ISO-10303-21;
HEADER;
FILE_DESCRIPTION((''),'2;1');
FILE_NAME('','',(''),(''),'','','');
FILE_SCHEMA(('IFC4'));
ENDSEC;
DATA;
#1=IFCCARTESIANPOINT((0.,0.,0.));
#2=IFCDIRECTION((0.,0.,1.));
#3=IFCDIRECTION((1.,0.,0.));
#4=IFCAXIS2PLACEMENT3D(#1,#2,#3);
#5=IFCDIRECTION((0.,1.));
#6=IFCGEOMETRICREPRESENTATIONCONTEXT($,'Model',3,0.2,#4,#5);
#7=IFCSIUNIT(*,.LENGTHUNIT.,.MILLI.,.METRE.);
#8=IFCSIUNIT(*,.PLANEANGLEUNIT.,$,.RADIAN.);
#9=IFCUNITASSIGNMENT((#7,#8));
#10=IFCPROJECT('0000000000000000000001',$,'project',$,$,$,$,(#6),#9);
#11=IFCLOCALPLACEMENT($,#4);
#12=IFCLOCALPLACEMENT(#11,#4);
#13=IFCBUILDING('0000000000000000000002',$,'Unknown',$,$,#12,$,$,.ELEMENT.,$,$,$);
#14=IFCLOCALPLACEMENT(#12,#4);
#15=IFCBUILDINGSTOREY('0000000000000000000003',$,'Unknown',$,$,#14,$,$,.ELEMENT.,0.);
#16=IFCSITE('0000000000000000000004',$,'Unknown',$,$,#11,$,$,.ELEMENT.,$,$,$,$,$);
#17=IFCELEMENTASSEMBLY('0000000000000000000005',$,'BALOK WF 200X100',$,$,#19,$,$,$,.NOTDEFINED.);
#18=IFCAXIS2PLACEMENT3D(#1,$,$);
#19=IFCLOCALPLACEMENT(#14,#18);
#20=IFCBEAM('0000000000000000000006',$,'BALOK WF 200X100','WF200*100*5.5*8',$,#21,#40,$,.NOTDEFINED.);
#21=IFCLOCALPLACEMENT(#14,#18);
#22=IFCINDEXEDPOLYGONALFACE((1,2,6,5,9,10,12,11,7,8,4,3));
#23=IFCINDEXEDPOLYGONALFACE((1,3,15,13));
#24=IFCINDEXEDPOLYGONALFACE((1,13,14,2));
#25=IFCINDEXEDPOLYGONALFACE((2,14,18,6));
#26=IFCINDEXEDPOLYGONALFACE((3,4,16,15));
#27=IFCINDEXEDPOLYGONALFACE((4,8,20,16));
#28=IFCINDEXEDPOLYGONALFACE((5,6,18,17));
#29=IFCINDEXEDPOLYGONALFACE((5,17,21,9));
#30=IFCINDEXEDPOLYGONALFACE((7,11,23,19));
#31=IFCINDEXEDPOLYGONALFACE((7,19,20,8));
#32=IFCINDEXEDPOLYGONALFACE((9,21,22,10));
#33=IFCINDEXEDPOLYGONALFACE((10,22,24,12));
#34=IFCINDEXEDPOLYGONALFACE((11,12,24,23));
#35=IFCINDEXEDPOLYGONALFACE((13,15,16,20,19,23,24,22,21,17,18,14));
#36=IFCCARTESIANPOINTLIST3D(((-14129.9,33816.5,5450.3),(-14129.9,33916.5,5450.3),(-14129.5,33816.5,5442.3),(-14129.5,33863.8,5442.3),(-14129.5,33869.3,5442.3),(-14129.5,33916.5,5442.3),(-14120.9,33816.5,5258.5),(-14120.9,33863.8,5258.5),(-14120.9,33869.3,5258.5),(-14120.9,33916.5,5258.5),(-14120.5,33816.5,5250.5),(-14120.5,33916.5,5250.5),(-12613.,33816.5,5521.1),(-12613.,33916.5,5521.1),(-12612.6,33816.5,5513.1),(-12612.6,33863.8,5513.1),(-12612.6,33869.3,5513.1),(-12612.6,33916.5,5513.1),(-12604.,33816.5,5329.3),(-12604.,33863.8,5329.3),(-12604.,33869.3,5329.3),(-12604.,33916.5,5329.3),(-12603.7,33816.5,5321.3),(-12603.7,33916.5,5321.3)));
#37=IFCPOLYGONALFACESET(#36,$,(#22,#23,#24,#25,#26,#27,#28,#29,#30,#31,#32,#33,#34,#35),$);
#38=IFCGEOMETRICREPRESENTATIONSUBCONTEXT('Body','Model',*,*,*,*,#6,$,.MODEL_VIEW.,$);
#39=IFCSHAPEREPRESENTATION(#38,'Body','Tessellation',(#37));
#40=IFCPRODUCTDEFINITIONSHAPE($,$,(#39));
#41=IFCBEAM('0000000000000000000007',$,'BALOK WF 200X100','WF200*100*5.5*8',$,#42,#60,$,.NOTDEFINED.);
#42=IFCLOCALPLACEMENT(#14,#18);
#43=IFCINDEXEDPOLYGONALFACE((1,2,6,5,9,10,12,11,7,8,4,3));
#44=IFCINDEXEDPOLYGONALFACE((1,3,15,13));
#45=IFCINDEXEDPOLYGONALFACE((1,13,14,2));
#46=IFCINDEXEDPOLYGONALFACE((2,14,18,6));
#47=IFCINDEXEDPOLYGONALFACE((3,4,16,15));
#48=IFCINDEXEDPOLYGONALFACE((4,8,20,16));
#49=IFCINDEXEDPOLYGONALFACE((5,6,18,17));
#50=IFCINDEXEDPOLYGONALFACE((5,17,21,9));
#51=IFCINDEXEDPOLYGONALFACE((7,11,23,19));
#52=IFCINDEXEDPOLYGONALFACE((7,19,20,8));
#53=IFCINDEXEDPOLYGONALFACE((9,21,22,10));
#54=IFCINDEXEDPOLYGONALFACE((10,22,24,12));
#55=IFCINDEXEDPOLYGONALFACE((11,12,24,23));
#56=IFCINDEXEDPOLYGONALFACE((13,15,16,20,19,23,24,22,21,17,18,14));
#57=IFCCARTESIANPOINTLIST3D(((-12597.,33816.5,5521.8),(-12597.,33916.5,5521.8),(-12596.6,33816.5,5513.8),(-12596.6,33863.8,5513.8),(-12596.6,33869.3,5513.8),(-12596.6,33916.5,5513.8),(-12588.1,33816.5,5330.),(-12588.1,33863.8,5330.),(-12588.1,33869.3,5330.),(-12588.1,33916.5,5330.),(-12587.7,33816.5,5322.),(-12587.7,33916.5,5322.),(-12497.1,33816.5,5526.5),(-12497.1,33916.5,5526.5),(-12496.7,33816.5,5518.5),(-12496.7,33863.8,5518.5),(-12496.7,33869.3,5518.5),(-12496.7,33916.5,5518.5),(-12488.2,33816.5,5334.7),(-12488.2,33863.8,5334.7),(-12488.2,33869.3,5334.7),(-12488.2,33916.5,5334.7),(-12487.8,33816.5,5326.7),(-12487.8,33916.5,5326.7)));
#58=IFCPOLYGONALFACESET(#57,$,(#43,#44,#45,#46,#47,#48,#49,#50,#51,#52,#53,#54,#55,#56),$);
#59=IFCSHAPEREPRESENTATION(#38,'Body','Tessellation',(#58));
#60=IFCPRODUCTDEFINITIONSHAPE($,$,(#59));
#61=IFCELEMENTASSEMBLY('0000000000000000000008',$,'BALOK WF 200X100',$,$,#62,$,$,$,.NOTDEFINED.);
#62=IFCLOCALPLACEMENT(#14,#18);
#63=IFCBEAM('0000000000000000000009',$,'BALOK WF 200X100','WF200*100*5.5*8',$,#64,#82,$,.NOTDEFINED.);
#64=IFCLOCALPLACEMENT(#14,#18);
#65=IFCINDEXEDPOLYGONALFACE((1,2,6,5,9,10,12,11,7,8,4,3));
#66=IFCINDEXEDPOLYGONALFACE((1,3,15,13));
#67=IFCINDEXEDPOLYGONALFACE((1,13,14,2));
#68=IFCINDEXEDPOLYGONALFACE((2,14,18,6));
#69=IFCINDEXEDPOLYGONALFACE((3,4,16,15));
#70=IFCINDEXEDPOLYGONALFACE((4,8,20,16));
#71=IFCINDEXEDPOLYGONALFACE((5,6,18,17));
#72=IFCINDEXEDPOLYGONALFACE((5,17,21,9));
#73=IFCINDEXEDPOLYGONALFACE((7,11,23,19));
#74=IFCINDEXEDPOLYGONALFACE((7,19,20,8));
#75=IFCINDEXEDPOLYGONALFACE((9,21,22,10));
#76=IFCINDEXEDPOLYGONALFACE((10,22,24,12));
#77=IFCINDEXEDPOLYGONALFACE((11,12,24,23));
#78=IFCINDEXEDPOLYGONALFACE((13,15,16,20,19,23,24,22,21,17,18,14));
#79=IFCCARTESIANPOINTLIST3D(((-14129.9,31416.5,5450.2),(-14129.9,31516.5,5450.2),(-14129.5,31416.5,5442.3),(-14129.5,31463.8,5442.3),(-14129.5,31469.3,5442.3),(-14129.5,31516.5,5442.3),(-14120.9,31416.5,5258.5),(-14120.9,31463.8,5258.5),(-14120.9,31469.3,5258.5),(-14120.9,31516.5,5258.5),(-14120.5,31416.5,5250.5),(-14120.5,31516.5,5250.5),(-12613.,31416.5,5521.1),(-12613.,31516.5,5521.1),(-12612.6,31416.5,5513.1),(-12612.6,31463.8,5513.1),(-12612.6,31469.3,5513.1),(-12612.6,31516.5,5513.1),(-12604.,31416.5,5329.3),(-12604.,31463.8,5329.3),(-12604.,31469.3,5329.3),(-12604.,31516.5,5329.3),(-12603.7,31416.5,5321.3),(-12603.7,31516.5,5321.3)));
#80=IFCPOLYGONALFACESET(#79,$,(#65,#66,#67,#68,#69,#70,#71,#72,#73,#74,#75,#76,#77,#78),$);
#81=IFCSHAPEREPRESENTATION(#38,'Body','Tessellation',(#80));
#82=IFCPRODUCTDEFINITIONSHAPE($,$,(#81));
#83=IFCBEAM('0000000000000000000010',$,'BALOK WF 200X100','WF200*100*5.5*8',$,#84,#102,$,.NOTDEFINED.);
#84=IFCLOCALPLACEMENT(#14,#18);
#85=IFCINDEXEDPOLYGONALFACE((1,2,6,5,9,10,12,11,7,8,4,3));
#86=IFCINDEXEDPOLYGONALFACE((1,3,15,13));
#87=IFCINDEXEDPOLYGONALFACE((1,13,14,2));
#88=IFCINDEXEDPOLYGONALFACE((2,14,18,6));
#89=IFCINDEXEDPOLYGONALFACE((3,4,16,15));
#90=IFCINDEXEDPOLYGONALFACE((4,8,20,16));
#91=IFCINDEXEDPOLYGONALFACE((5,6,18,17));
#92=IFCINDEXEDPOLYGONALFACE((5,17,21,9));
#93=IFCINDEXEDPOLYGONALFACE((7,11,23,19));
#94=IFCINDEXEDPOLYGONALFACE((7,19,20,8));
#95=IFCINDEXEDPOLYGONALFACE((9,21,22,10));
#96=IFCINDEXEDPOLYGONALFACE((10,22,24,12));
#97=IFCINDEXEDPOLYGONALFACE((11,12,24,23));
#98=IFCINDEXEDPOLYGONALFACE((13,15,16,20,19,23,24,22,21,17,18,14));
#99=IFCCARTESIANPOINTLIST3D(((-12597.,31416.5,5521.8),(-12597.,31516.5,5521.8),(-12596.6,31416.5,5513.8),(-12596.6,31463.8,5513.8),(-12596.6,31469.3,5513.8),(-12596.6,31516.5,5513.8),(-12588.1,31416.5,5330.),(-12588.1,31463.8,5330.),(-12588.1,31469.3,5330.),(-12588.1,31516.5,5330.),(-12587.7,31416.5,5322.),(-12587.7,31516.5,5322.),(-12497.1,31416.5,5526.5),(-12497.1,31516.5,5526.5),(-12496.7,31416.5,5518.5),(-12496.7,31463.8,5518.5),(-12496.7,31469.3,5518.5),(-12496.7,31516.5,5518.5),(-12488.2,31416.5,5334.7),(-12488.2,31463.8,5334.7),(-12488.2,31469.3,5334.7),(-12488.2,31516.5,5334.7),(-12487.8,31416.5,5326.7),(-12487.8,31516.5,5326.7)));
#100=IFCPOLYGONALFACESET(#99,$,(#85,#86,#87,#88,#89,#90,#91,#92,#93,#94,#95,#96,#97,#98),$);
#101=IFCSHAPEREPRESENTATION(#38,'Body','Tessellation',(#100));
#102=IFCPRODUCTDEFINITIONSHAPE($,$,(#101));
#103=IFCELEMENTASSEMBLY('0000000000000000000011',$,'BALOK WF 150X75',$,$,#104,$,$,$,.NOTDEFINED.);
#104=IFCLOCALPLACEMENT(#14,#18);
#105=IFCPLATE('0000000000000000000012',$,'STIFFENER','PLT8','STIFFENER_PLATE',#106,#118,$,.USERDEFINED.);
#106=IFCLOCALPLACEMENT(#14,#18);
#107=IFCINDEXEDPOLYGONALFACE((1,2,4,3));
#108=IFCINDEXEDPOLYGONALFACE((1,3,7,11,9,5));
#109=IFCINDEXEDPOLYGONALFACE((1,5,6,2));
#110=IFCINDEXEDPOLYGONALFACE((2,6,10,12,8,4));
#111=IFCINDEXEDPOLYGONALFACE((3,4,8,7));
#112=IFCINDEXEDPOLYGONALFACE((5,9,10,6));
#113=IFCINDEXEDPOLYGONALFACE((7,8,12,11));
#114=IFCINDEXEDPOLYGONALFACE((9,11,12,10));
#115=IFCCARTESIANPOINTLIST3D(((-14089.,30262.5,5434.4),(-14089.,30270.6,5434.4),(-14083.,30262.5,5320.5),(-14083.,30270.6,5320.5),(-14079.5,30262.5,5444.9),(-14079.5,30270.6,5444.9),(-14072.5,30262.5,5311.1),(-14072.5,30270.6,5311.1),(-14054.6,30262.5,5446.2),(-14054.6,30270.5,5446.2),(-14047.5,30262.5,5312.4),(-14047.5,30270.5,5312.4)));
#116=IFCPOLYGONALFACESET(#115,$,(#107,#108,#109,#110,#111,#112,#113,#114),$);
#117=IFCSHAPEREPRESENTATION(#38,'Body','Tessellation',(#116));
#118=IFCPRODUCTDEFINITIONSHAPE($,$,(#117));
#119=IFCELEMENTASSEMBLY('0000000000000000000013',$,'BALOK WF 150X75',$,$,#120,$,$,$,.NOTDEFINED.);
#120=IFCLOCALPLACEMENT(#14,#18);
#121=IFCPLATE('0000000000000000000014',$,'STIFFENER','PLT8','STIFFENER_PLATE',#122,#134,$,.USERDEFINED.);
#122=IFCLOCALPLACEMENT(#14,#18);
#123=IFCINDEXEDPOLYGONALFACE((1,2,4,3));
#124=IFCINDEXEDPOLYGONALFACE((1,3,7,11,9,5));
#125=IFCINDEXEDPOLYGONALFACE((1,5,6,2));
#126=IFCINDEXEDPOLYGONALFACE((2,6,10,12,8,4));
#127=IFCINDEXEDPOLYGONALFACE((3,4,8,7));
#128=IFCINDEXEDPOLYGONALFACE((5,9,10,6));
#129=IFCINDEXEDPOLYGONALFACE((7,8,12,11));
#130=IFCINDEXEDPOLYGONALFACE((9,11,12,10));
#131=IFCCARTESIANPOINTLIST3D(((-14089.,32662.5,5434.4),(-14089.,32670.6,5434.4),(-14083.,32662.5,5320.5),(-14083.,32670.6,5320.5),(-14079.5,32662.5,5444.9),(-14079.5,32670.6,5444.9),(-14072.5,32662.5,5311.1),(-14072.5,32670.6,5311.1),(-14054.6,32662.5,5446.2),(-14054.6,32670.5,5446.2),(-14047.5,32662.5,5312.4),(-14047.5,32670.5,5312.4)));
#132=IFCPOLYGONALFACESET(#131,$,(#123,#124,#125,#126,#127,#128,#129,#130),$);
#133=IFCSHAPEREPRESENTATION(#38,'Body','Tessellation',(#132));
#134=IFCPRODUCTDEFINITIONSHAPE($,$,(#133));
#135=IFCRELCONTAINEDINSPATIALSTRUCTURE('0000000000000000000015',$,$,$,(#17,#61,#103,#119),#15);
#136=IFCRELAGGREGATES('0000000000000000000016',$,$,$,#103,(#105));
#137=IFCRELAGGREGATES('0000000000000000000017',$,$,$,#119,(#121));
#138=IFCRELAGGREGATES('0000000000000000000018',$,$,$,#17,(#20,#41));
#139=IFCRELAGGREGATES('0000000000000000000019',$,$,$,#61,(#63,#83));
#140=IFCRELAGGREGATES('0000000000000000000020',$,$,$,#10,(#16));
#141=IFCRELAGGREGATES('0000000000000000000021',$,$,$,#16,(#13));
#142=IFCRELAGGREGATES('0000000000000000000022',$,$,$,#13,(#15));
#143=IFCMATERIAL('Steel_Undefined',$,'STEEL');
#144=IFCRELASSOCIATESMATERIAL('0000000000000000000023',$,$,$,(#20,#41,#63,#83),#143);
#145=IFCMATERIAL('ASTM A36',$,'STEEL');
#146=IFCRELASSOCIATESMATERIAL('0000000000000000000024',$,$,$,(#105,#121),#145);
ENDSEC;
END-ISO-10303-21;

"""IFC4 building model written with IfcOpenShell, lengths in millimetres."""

from ifc_helpers import new_model, si_unit, direction, frame, origin_with_axes, place, context, subcontext, project, spatial, line, indexed_curve, outline, extrude, material, element, aggregate, save


model = new_model("IFC4")

# Units and contexts
model_context = context("Model", 3, precision=0.2, world=origin_with_axes(), true_north=direction((0.0, 1.0)))
body_context = subcontext(model_context, "Body", "Model", "MODEL_VIEW")
ifc_project = project(units=[si_unit("LENGTHUNIT", "METRE", prefix="MILLI"), si_unit("PLANEANGLEUNIT", "RADIAN")], contexts=[model_context])

# Site, building, storey
site_placement = place(None, origin_with_axes())
site = spatial("IfcSite", under=ifc_project, at=site_placement, Name="Unknown", CompositionType="ELEMENT")
building_placement = place(site_placement, origin_with_axes())
building = spatial("IfcBuilding", under=site, at=building_placement, Name="Unknown", CompositionType="ELEMENT")
storey_placement = place(building_placement, origin_with_axes())
storey = spatial("IfcBuildingStorey", under=building, at=storey_placement, Name="Unknown", CompositionType="ELEMENT", Elevation=0.0)

# Element assemblies, beams
assembly_1_placement = place(storey_placement, frame((-12608.3, 33866.5, 5421.2), z_axis=(0.0, 1.0, 0.0), x_axis=(-0.998912, 0.0, -0.046636)))
assembly_1 = element("IfcElementAssembly", 1, at=assembly_1_placement, inside=storey, Name="BALOK WF 200X100", PredefinedType="NOTDEFINED")
ifc_material_1 = material(Name="Steel_Undefined", Category="STEEL")
beam_1_placement = place(assembly_1_placement, origin_with_axes())
beam_1 = element("IfcBeam", 2, at=beam_1_placement, material=ifc_material_1, Name="BALOK WF 200X100", Description="WF200*100*5.5*8", PredefinedType="NOTDEFINED", context=body_context, shape_type="SolidModel", body=[
    extrude(outline(indexed_curve([(-50.0, -100.0), (50.0, -100.0), (50.0, -92.0), (2.8, -92.0), (2.8, 92.0), (50.0, 92.0), (50.0, 100.0), (-50.0, 100.0), (-50.0, 92.0), (-2.8, 92.0), (-2.8, -92.0), (-50.0, -92.0)], segments=[line(1, 2, 3, 4, 5, 6, 7, 8, 9, 10, 11, 12, 1)])), frame((0.0, 0.0, 0.0), z_axis=(-1.0, 0.0, 0.0), x_axis=(0.0, 0.0, 1.0)), (0.0, 0.0, -1.0), 1518.5),
])
beam_2_placement = place(assembly_1_placement, frame((-116.0, 0.0, 0.0), z_axis=(0.0, 0.0, 1.0), x_axis=(1.0, 0.0, 0.0)))
beam_2 = element("IfcBeam", 3, at=beam_2_placement, material=ifc_material_1, Name="BALOK WF 200X100", Description="WF200*100*5.5*8", PredefinedType="NOTDEFINED", context=body_context, shape_type="SolidModel", body=[
    extrude(outline(indexed_curve([(-50.0, -100.0), (50.0, -100.0), (50.0, -92.0), (2.8, -92.0), (2.8, 92.0), (50.0, 92.0), (50.0, 100.0), (-50.0, 100.0), (-50.0, 92.0), (-2.8, 92.0), (-2.8, -92.0), (-50.0, -92.0)], segments=[line(1, 2, 3, 4, 5, 6, 7, 8, 9, 10, 11, 12, 1)])), frame((0.0, 0.0, 0.0), z_axis=(-1.0, 0.0, 0.0), x_axis=(0.0, 0.0, 1.0)), (0.0, 0.0, -1.0), 100.0),
])
assembly_2_placement = place(storey_placement, frame((-12608.3, 31466.5, 5421.2), z_axis=(0.0, 1.0, 0.0), x_axis=(-0.998912, 0.0, -0.046636)))
assembly_2 = element("IfcElementAssembly", 4, at=assembly_2_placement, inside=storey, Name="BALOK WF 200X100", PredefinedType="NOTDEFINED")
beam_3_placement = place(assembly_2_placement, origin_with_axes())
beam_3 = element("IfcBeam", 5, at=beam_3_placement, material=ifc_material_1, Name="BALOK WF 200X100", Description="WF200*100*5.5*8", PredefinedType="NOTDEFINED", context=body_context, shape_type="SolidModel", body=[
    extrude(outline(indexed_curve([(-50.0, -100.0), (50.0, -100.0), (50.0, -92.0), (2.8, -92.0), (2.8, 92.0), (50.0, 92.0), (50.0, 100.0), (-50.0, 100.0), (-50.0, 92.0), (-2.8, 92.0), (-2.8, -92.0), (-50.0, -92.0)], segments=[line(1, 2, 3, 4, 5, 6, 7, 8, 9, 10, 11, 12, 1)])), frame((0.0, 0.0, 0.0), z_axis=(-1.0, 0.0, 0.0), x_axis=(0.0, 0.0, 1.0)), (0.0, 0.0, -1.0), 1518.5),
])
beam_4_placement = place(assembly_2_placement, frame((-116.0, 0.0, 0.0), z_axis=(0.0, 0.0, 1.0), x_axis=(1.0, 0.0, 0.0)))
beam_4 = element("IfcBeam", 6, at=beam_4_placement, material=ifc_material_1, Name="BALOK WF 200X100", Description="WF200*100*5.5*8", PredefinedType="NOTDEFINED", context=body_context, shape_type="SolidModel", body=[
    extrude(outline(indexed_curve([(-50.0, -100.0), (50.0, -100.0), (50.0, -92.0), (2.8, -92.0), (2.8, 92.0), (50.0, 92.0), (50.0, 100.0), (-50.0, 100.0), (-50.0, 92.0), (-2.8, 92.0), (-2.8, -92.0), (-50.0, -92.0)], segments=[line(1, 2, 3, 4, 5, 6, 7, 8, 9, 10, 11, 12, 1)])), frame((0.0, 0.0, 0.0), z_axis=(-1.0, 0.0, 0.0), x_axis=(0.0, 0.0, 1.0)), (0.0, 0.0, -1.0), 100.0),
])

# Element assembly, plate, voiding features
assembly_3_placement = place(storey_placement, frame((-14088.5, 31625.4, 5377.3), z_axis=(-0.99863, 0.0, -0.052336), x_axis=(0.0, -1.0, 0.000001)))
assembly_3 = element("IfcElementAssembly", 7, at=assembly_3_placement, inside=storey, Name="BALOK WF 150X75", PredefinedType="NOTDEFINED")
ifc_material_2 = material(Name="ASTM A36", Category="STEEL")
plate_1_placement = place(assembly_3_placement, frame((1358.9, 67.0, -37.5), z_axis=(1.0, 0.0, 0.0), x_axis=(0.0, 0.0, 1.0)))
plate_1 = element("IfcPlate", 8, at=plate_1_placement, material=ifc_material_2, Name="STIFFENER", Description="PLT8", ObjectType="STIFFENER_PLATE", PredefinedType="USERDEFINED", context=body_context, shape_type="SolidModel", body=[
    extrude(outline(indexed_curve([(0.0, 0.0), (35.0, 0.0), (35.0, 134.0), (0.0, 134.0)], segments=[line(1, 2, 3, 4, 1)])), frame((0.0, 0.0, 4.0), z_axis=(0.0, 0.0, 1.0), x_axis=(1.0, 0.0, 0.0)), (0.0, 0.0, -1.0), 8.0),
])
voiding_feature_1_placement = place(plate_1_placement, frame((25.0, 134.0, 0.0), z_axis=(0.0, 0.0, 1.0), x_axis=(0.707107, -0.707107, 0.0)))
element("IfcVoidingFeature", 9, at=voiding_feature_1_placement, cuts=plate_1, Name="SLAB", PredefinedType="HOLE", context=body_context, shape_type="SolidModel", body=[
    extrude(outline(indexed_curve([(0.0, 0.0), (14.1, 0.0), (7.1, 7.1)], segments=[line(1, 2, 3, 1)])), frame((0.0, 0.0, 4.0), z_axis=(0.0, 0.0, 1.0), x_axis=(1.0, 0.0, 0.0)), (0.0, 0.0, -1.0), 8.0),
])
voiding_feature_2_placement = place(plate_1_placement, frame((25.0, 0.0, 0.0), z_axis=(0.0, 0.0, 1.0), x_axis=(1.0, 0.0, 0.0)))
element("IfcVoidingFeature", 10, at=voiding_feature_2_placement, cuts=plate_1, Name="SLAB", PredefinedType="HOLE", context=body_context, shape_type="SolidModel", body=[
    extrude(outline(indexed_curve([(0.0, 0.0), (10.0, 0.0), (10.0, 10.0)], segments=[line(1, 2, 3, 1)])), frame((0.0, 0.0, 4.0), z_axis=(0.0, 0.0, 1.0), x_axis=(1.0, 0.0, 0.0)), (0.0, 0.0, -1.0), 8.0),
])
aggregate(assembly_3, [plate_1])

# Element assembly, plate, voiding features
assembly_4_placement = place(storey_placement, frame((-14088.5, 34025.4, 5377.3), z_axis=(-0.99863, 0.0, -0.052336), x_axis=(0.0, -1.0, 0.0)))
assembly_4 = element("IfcElementAssembly", 11, at=assembly_4_placement, inside=storey, Name="BALOK WF 150X75", PredefinedType="NOTDEFINED")
plate_2_placement = place(assembly_4_placement, frame((1358.9, 67.0, -37.5), z_axis=(1.0, 0.0, 0.0), x_axis=(0.0, 0.0, 1.0)))
plate_2 = element("IfcPlate", 12, at=plate_2_placement, material=ifc_material_2, Name="STIFFENER", Description="PLT8", ObjectType="STIFFENER_PLATE", PredefinedType="USERDEFINED", context=body_context, shape_type="SolidModel", body=[
    extrude(outline(indexed_curve([(0.0, 0.0), (35.0, 0.0), (35.0, 134.0), (0.0, 134.0)], segments=[line(1, 2, 3, 4, 1)])), frame((0.0, 0.0, 4.0), z_axis=(0.0, 0.0, 1.0), x_axis=(1.0, 0.0, 0.0)), (0.0, 0.0, -1.0), 8.0),
])
voiding_feature_3_placement = place(plate_2_placement, frame((25.0, 134.0, 0.0), z_axis=(0.0, 0.0, 1.0), x_axis=(0.707107, -0.707107, 0.0)))
element("IfcVoidingFeature", 13, at=voiding_feature_3_placement, cuts=plate_2, Name="SLAB", PredefinedType="HOLE", context=body_context, shape_type="SolidModel", body=[
    extrude(outline(indexed_curve([(0.0, 0.0), (14.1, 0.0), (7.1, 7.1)], segments=[line(1, 2, 3, 1)])), frame((0.0, 0.0, 4.0), z_axis=(0.0, 0.0, 1.0), x_axis=(1.0, 0.0, 0.0)), (0.0, 0.0, -1.0), 8.0),
])
voiding_feature_4_placement = place(plate_2_placement, frame((25.0, 0.0, 0.0), z_axis=(0.0, 0.0, 1.0), x_axis=(1.0, 0.0, 0.0)))
element("IfcVoidingFeature", 14, at=voiding_feature_4_placement, cuts=plate_2, Name="SLAB", PredefinedType="HOLE", context=body_context, shape_type="SolidModel", body=[
    extrude(outline(indexed_curve([(0.0, 0.0), (10.0, 0.0), (10.0, 10.0)], segments=[line(1, 2, 3, 1)])), frame((0.0, 0.0, 4.0), z_axis=(0.0, 0.0, 1.0), x_axis=(1.0, 0.0, 0.0)), (0.0, 0.0, -1.0), 8.0),
])
aggregate(assembly_4, [plate_2])

aggregate(assembly_1, [beam_1, beam_2])
aggregate(assembly_2, [beam_3, beam_4])

save(model, "model.ifc")
